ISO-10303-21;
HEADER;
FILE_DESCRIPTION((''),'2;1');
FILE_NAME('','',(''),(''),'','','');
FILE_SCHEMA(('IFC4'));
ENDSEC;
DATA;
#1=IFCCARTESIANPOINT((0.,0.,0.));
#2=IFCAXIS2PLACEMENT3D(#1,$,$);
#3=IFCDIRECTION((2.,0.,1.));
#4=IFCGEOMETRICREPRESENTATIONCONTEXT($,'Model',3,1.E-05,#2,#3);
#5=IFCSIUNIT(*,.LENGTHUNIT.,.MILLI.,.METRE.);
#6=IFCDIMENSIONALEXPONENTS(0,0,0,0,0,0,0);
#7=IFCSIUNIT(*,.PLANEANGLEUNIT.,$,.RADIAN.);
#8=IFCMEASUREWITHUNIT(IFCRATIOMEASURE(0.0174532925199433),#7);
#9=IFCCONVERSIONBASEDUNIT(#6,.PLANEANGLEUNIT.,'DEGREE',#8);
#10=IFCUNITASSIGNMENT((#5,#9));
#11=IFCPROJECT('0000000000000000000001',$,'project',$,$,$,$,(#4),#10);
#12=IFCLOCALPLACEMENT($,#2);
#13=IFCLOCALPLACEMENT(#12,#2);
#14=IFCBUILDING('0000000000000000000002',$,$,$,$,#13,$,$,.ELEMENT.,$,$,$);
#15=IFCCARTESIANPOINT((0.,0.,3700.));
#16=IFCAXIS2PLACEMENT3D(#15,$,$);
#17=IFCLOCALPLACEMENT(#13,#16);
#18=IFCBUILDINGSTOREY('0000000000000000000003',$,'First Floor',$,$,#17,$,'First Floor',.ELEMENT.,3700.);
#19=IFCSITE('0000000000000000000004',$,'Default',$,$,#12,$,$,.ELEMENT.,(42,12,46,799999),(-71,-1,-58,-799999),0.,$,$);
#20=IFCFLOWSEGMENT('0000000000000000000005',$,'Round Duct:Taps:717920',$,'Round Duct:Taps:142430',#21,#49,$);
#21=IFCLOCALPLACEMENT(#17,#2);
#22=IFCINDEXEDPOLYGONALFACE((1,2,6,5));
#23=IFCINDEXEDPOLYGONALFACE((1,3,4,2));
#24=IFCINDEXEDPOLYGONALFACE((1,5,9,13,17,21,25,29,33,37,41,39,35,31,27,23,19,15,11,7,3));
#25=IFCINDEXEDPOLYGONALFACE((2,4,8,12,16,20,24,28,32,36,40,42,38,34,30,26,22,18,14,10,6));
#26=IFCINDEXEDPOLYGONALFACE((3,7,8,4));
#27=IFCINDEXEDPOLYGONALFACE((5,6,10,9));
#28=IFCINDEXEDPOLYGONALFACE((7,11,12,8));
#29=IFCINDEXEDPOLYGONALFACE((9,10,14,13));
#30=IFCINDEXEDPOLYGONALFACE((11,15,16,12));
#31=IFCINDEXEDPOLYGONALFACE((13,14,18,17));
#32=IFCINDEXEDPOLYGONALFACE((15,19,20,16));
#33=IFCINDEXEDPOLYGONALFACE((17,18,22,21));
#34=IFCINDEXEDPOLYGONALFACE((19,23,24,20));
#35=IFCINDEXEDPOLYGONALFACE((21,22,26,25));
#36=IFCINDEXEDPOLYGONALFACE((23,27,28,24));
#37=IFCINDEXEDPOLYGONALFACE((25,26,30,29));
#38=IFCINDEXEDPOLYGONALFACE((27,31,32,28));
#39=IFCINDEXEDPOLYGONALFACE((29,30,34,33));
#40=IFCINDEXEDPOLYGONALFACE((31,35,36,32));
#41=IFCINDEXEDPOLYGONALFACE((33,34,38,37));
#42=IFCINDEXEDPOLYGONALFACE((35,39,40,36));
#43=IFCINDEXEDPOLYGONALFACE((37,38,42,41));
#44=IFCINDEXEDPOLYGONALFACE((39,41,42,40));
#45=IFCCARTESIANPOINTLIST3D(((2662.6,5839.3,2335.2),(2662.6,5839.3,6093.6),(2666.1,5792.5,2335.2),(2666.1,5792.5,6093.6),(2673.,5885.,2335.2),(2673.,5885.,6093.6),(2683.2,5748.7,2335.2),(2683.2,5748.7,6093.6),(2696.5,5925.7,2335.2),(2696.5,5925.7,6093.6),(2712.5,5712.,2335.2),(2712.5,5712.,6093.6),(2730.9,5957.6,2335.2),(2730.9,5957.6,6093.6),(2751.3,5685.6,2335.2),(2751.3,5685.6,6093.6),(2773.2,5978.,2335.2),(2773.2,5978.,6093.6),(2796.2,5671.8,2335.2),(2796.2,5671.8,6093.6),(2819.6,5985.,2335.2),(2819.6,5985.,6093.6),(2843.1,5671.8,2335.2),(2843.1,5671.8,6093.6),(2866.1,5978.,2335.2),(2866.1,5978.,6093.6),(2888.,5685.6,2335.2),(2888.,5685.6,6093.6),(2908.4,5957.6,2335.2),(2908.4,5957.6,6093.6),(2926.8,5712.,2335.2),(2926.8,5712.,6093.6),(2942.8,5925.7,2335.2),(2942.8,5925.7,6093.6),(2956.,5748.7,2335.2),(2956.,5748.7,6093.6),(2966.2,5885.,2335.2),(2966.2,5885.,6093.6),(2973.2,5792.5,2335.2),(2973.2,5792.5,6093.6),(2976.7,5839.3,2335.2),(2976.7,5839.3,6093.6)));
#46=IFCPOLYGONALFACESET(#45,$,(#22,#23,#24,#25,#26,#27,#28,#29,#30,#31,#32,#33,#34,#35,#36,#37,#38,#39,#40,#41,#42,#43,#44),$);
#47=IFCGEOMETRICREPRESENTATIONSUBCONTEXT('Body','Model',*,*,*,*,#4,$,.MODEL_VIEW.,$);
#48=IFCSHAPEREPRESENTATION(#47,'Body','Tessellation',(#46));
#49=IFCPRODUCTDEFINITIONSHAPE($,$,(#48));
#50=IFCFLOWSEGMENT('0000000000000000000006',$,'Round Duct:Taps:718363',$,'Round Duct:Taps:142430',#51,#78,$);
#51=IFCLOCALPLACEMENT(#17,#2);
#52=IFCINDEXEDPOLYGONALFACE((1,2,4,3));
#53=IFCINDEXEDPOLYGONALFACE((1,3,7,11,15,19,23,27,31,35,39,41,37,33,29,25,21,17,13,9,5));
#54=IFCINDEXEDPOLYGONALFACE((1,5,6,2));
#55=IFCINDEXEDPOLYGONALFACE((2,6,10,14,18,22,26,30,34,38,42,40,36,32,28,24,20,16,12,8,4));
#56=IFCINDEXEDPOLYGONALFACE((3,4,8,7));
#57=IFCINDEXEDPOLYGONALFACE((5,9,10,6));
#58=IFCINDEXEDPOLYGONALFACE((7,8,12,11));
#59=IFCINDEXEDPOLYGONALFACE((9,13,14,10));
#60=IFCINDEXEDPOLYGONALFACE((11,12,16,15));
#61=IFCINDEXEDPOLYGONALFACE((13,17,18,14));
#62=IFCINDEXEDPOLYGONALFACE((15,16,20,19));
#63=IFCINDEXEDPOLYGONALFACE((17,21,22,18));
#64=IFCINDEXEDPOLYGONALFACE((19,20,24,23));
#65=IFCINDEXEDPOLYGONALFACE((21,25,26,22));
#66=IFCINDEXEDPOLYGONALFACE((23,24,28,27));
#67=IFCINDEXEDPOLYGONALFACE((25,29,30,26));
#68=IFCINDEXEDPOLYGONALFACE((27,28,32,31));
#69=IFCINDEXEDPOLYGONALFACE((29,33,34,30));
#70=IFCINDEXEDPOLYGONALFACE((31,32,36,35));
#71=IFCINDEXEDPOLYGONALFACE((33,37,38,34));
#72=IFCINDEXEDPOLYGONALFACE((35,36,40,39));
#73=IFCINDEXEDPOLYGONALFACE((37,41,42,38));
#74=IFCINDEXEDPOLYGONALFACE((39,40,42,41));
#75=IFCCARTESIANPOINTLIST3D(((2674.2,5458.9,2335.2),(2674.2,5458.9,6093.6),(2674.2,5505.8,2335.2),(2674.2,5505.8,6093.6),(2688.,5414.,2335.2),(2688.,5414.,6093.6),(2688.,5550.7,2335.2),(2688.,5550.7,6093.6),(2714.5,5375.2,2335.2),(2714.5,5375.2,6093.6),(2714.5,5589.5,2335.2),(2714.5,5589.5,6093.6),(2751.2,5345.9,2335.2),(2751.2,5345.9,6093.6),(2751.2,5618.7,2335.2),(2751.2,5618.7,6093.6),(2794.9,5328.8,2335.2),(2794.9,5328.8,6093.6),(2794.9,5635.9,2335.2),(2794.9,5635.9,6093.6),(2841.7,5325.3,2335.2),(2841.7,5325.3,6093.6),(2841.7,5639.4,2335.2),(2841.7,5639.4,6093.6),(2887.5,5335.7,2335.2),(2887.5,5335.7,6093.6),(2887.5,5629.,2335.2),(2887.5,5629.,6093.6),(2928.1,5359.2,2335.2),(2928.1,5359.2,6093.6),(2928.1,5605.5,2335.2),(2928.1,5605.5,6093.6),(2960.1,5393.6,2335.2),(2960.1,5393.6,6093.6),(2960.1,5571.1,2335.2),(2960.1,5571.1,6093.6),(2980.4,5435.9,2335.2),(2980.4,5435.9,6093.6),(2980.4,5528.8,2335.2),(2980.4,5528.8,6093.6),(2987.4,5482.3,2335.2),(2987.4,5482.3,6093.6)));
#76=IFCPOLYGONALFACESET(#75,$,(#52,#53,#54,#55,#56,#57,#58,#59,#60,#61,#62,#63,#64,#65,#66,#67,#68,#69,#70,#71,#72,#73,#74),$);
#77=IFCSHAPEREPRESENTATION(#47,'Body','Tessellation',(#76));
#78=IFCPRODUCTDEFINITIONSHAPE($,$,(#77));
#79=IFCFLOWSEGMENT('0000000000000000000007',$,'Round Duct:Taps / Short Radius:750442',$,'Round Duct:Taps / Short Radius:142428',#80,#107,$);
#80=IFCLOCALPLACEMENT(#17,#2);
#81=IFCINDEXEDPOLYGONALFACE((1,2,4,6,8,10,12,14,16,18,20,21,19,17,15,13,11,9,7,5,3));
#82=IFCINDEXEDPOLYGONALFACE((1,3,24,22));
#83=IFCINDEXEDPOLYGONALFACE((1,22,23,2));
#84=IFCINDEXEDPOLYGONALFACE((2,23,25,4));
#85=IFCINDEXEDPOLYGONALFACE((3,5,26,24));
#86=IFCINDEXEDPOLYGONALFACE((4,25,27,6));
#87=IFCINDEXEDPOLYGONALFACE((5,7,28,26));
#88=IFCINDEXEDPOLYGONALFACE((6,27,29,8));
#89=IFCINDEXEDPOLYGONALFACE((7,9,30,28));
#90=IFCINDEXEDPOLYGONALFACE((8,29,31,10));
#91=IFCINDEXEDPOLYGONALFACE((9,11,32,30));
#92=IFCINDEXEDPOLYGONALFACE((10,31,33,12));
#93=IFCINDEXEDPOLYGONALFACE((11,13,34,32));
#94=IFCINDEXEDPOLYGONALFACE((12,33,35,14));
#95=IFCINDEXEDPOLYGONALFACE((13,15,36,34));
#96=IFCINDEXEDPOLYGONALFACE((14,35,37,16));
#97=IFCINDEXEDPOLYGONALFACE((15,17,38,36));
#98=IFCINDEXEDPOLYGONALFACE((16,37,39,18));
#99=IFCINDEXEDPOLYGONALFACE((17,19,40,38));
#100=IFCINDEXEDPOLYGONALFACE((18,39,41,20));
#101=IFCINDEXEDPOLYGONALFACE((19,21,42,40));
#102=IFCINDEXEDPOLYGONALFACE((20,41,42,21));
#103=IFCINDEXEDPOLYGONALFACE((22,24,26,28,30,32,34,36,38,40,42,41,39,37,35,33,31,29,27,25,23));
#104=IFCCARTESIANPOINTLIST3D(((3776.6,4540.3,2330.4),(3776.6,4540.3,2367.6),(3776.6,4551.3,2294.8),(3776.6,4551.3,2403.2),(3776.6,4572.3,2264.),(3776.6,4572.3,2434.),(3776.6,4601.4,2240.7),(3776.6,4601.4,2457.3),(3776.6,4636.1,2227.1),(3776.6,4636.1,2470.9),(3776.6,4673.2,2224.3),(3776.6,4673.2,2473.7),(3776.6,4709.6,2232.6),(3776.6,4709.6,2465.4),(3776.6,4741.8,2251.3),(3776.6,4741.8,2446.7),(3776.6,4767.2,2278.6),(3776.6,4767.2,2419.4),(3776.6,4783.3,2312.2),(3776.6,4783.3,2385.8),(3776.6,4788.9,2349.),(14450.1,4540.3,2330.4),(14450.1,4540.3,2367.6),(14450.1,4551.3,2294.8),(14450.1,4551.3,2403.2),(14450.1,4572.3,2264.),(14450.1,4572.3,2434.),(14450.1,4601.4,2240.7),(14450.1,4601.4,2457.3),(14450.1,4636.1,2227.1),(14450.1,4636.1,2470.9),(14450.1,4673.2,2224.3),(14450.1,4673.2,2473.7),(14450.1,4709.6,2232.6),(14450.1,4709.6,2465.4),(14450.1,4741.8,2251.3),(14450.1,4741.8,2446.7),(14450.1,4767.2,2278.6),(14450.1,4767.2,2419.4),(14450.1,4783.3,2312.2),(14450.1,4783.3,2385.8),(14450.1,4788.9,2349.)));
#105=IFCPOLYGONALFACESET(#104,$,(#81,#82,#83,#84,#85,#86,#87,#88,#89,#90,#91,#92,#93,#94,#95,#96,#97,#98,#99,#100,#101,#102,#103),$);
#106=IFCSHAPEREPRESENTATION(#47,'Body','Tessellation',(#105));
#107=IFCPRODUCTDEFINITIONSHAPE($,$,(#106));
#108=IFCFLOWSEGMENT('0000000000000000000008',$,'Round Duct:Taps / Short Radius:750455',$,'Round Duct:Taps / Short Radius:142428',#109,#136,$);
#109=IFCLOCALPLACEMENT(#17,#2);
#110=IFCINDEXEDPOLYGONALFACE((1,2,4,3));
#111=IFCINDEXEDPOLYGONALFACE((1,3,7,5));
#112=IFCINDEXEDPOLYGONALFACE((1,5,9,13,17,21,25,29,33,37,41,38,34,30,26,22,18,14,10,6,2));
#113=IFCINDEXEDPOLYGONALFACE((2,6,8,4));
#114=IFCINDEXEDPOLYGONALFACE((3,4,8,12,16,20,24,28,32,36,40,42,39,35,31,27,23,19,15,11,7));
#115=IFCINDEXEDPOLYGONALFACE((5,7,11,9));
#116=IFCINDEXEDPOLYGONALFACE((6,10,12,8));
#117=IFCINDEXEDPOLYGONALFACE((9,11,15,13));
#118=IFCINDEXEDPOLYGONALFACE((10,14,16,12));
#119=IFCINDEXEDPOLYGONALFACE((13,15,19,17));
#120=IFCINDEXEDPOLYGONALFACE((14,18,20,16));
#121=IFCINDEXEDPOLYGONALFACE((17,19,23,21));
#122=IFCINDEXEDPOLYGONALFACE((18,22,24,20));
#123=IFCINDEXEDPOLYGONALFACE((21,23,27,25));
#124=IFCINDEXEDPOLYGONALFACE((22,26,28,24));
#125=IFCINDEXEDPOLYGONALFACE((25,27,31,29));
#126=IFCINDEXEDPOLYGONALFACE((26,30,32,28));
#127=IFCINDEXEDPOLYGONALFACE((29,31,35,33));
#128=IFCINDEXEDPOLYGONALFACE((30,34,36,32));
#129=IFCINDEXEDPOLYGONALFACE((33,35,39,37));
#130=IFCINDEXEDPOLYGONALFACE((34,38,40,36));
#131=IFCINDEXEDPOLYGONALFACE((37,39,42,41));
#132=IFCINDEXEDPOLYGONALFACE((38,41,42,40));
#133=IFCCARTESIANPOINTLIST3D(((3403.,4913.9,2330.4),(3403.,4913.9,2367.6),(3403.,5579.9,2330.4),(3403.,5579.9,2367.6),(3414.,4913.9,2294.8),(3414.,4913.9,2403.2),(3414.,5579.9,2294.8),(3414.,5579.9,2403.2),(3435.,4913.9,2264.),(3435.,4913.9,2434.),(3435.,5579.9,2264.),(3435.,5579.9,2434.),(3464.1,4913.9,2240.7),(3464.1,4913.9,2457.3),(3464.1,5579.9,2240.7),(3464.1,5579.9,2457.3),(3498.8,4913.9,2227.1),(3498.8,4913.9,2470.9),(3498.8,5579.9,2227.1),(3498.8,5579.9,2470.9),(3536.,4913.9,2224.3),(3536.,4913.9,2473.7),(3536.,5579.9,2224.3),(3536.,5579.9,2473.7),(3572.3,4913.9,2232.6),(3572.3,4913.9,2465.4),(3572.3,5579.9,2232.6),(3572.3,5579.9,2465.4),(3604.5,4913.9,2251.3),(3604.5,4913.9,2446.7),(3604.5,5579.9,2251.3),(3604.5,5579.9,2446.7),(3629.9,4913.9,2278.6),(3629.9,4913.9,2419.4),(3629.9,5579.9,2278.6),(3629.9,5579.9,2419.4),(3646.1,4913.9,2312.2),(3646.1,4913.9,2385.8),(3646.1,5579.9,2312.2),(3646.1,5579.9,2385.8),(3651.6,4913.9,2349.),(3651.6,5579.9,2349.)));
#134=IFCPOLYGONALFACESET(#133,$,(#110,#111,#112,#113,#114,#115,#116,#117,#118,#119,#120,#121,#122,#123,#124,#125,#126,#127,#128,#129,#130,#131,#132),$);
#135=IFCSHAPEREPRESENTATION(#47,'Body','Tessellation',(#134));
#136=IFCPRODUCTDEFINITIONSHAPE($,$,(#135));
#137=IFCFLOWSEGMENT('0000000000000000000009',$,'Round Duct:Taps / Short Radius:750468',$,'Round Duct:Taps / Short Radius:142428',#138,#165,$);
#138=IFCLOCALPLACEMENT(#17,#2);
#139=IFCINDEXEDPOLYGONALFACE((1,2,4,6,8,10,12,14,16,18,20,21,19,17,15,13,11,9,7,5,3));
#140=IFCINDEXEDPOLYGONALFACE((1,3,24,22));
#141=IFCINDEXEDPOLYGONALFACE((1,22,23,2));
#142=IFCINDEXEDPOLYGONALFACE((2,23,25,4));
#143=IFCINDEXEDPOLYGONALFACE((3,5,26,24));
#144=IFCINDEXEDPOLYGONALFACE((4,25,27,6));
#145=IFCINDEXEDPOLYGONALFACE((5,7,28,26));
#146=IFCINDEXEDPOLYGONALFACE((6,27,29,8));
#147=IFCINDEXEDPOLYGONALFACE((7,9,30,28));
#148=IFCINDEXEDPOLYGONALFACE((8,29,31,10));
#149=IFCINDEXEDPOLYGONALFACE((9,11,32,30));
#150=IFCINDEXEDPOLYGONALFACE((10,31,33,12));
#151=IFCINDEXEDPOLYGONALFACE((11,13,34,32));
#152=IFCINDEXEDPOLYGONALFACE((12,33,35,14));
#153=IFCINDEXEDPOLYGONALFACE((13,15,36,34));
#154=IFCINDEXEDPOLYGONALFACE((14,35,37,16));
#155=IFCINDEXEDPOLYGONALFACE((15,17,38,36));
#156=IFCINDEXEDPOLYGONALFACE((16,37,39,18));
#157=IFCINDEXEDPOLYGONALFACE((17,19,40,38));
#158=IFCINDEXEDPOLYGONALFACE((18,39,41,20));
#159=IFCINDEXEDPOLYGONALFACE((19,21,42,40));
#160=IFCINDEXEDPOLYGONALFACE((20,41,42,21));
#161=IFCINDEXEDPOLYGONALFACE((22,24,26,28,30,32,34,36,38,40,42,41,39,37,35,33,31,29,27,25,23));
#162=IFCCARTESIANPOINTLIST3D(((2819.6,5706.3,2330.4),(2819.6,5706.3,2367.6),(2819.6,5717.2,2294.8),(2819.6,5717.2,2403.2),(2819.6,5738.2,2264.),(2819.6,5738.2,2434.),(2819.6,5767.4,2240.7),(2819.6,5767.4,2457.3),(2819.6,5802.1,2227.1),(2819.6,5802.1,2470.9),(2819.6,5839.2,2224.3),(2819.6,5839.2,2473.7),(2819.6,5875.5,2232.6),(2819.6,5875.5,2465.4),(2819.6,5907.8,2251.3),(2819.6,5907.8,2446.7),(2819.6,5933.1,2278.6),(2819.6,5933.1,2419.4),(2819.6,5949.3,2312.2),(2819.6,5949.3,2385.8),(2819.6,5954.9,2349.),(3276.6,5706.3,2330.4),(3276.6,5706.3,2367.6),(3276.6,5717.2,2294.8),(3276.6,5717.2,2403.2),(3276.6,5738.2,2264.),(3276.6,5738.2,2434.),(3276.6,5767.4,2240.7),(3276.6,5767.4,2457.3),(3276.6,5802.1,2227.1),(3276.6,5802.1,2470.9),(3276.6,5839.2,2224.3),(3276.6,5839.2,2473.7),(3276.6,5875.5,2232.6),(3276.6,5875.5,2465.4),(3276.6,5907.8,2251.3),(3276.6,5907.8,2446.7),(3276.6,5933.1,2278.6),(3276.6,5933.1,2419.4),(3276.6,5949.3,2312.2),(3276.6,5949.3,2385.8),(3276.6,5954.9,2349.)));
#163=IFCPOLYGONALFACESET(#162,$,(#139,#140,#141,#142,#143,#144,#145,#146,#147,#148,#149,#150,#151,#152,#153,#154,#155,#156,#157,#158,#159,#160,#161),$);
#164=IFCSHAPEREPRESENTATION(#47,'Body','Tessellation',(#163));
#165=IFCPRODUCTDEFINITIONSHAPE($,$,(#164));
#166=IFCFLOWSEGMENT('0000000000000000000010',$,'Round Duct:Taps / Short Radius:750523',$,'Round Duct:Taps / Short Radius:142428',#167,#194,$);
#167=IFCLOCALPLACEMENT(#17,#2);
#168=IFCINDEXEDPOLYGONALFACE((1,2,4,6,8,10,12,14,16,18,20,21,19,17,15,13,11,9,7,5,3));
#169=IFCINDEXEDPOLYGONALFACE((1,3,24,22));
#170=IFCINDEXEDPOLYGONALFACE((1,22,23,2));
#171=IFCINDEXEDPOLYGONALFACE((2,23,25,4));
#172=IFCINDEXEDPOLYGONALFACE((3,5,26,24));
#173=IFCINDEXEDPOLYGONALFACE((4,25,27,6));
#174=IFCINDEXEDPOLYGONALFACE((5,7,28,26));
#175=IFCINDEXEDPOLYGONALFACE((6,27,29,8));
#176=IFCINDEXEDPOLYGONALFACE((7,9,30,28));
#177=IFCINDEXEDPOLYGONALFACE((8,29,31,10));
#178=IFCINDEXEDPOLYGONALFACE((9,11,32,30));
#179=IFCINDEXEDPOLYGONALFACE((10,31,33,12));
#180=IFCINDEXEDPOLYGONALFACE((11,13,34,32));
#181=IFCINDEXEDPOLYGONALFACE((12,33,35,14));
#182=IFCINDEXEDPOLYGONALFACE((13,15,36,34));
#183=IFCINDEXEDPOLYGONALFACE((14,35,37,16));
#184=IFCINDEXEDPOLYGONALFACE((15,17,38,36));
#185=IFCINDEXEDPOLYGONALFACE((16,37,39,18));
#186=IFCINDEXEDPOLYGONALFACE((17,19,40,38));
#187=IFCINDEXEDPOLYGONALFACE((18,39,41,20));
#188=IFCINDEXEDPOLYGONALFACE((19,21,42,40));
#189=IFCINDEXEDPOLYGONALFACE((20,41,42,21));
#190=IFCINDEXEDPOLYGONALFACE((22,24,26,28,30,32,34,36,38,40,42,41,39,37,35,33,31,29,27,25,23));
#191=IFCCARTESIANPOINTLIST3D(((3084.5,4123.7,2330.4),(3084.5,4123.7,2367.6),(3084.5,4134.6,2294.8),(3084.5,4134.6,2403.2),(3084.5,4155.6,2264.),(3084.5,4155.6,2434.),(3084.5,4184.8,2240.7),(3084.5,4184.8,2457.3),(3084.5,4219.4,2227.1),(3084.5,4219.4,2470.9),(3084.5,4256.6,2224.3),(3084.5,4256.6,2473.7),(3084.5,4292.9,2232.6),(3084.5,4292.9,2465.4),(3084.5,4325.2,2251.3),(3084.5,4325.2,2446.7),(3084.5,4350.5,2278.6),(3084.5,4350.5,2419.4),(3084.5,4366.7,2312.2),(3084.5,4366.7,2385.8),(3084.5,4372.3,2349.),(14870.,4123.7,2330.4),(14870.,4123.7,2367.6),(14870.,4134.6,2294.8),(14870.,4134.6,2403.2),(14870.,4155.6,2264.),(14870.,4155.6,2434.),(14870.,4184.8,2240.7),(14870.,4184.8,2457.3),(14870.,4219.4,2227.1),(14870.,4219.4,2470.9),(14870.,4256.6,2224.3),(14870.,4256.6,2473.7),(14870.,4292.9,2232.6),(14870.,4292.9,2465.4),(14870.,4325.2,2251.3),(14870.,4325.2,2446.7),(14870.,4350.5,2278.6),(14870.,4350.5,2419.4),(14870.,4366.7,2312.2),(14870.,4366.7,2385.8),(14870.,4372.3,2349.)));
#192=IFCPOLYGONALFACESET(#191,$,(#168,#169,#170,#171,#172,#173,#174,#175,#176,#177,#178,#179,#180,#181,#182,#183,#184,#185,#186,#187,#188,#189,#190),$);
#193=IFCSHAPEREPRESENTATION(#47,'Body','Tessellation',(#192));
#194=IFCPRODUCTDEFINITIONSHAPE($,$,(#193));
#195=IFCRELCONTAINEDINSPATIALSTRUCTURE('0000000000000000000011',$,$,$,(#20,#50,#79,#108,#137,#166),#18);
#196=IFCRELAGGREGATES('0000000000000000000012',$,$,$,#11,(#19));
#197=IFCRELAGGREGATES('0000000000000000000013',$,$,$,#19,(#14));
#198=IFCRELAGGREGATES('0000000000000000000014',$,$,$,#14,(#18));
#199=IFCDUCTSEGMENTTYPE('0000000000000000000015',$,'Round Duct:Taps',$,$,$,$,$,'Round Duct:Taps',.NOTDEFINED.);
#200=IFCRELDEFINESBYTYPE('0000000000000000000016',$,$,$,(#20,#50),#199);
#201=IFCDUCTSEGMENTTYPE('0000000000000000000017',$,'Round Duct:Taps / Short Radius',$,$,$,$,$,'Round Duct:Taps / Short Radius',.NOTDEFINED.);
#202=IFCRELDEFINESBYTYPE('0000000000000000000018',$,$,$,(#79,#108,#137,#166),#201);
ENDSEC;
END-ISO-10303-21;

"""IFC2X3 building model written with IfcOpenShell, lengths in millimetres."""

from ifc_helpers import new_model, entity, si_unit, converted_unit, direction, frame, frame_2d, origin, place, context, subcontext, project, spatial, circle, extrude, type_object, element, save


model = new_model("IFC2X3")

# Units and contexts
model_context = context("Model", 3, precision=1e-05, world=origin(), true_north=direction((2.0, 0.0, 1.0)))
body_context = subcontext(model_context, "Body", "Model", "MODEL_VIEW")
ifc_project = project(units=[si_unit("LENGTHUNIT", "METRE", prefix="MILLI"), converted_unit("PLANEANGLEUNIT", "DEGREE", entity("IfcRatioMeasure", 0.0174532925199433), si_unit("PLANEANGLEUNIT", "RADIAN"), dimensions=[0, 0, 0, 0, 0, 0, 0])], contexts=[model_context])

# Site, building, storey
site_placement = place(None, origin())
site = spatial("IfcSite", under=ifc_project, at=site_placement, Name="Default", CompositionType="ELEMENT", RefLatitude=(42, 12, 46, 799999), RefLongitude=(-71, -1, -58, -799999), RefElevation=0.0)
building_placement = place(site_placement, origin())
building = spatial("IfcBuilding", under=site, at=building_placement, CompositionType="ELEMENT")
storey_placement = place(building_placement, frame((0.0, 0.0, 3700.0)))
storey = spatial("IfcBuildingStorey", under=building, at=storey_placement, Name="First Floor", LongName="First Floor", CompositionType="ELEMENT", Elevation=3700.0)

# Flow segments
duct_segment_type_1 = type_object("IfcDuctSegmentType", Name="Round Duct:Taps", ElementType="Round Duct:Taps", PredefinedType="NOTDEFINED")
flow_segment_1_placement = place(storey_placement, origin())
element("IfcFlowSegment", 1, at=flow_segment_1_placement, inside=storey, type_object=duct_segment_type_1, Name="Round Duct:Taps:717920", ObjectType="Round Duct:Taps:142430", context=body_context, shape_type="SweptSolid", body=[
    extrude(circle(Radius=157.5, at=frame_2d((0.0, 0.0), x_axis=(1.0, 0.0))), frame((2819.6, 5827.5, 2335.2), z_axis=(0.0, 0.0, 1.0), x_axis=(0.0, 1.0, 0.0)), (0.0, 0.0, 1.0), 3758.4),
])
flow_segment_2_placement = place(storey_placement, origin())
element("IfcFlowSegment", 2, at=flow_segment_2_placement, inside=storey, type_object=duct_segment_type_1, Name="Round Duct:Taps:718363", ObjectType="Round Duct:Taps:142430", context=body_context, shape_type="SweptSolid", body=[
    extrude(circle(Radius=157.5, at=frame_2d((0.0, 0.0), x_axis=(1.0, 0.0))), frame((2829.9, 5482.3, 2335.2)), (0.0, 0.0, 1.0), 3758.4),
])
duct_segment_type_2 = type_object("IfcDuctSegmentType", Name="Round Duct:Taps / Short Radius", ElementType="Round Duct:Taps / Short Radius", PredefinedType="NOTDEFINED")
flow_segment_3_placement = place(storey_placement, origin())
element("IfcFlowSegment", 3, at=flow_segment_3_placement, inside=storey, type_object=duct_segment_type_2, Name="Round Duct:Taps / Short Radius:750442", ObjectType="Round Duct:Taps / Short Radius:142428", context=body_context, shape_type="SweptSolid", body=[
    extrude(circle(Radius=125.0, at=frame_2d((0.0, 0.0), x_axis=(1.0, 0.0))), frame((3776.6, 4663.9, 2349.0), z_axis=(1.0, 0.0, 0.0), x_axis=(0.0, 1.0, 0.0)), (0.0, 0.0, 1.0), 10673.5),
])
flow_segment_4_placement = place(storey_placement, origin())
element("IfcFlowSegment", 4, at=flow_segment_4_placement, inside=storey, type_object=duct_segment_type_2, Name="Round Duct:Taps / Short Radius:750455", ObjectType="Round Duct:Taps / Short Radius:142428", context=body_context, shape_type="SweptSolid", body=[
    extrude(circle(Radius=125.0, at=frame_2d((0.0, 0.0), x_axis=(1.0, 0.0))), frame((3526.6, 4913.9, 2349.0), z_axis=(0.0, 1.0, 0.0), x_axis=(1.0, 0.0, 0.0)), (0.0, 0.0, 1.0), 666.0),
])
flow_segment_5_placement = place(storey_placement, origin())
element("IfcFlowSegment", 5, at=flow_segment_5_placement, inside=storey, type_object=duct_segment_type_2, Name="Round Duct:Taps / Short Radius:750468", ObjectType="Round Duct:Taps / Short Radius:142428", context=body_context, shape_type="SweptSolid", body=[
    extrude(circle(Radius=125.0, at=frame_2d((0.0, 0.0), x_axis=(1.0, 0.0))), frame((2819.6, 5829.9, 2349.0), z_axis=(1.0, 0.0, 0.0), x_axis=(0.0, 1.0, 0.0)), (0.0, 0.0, 1.0), 457.0),
])
flow_segment_6_placement = place(storey_placement, origin())
element("IfcFlowSegment", 6, at=flow_segment_6_placement, inside=storey, type_object=duct_segment_type_2, Name="Round Duct:Taps / Short Radius:750523", ObjectType="Round Duct:Taps / Short Radius:142428", context=body_context, shape_type="SweptSolid", body=[
    extrude(circle(Radius=125.0, at=frame_2d((0.0, 0.0), x_axis=(1.0, 0.0))), frame((3084.5, 4247.3, 2349.0), z_axis=(1.0, 0.0, 0.0), x_axis=(0.0, 1.0, 0.0)), (0.0, 0.0, 1.0), 11785.4),
])

save(model, "model.ifc")
